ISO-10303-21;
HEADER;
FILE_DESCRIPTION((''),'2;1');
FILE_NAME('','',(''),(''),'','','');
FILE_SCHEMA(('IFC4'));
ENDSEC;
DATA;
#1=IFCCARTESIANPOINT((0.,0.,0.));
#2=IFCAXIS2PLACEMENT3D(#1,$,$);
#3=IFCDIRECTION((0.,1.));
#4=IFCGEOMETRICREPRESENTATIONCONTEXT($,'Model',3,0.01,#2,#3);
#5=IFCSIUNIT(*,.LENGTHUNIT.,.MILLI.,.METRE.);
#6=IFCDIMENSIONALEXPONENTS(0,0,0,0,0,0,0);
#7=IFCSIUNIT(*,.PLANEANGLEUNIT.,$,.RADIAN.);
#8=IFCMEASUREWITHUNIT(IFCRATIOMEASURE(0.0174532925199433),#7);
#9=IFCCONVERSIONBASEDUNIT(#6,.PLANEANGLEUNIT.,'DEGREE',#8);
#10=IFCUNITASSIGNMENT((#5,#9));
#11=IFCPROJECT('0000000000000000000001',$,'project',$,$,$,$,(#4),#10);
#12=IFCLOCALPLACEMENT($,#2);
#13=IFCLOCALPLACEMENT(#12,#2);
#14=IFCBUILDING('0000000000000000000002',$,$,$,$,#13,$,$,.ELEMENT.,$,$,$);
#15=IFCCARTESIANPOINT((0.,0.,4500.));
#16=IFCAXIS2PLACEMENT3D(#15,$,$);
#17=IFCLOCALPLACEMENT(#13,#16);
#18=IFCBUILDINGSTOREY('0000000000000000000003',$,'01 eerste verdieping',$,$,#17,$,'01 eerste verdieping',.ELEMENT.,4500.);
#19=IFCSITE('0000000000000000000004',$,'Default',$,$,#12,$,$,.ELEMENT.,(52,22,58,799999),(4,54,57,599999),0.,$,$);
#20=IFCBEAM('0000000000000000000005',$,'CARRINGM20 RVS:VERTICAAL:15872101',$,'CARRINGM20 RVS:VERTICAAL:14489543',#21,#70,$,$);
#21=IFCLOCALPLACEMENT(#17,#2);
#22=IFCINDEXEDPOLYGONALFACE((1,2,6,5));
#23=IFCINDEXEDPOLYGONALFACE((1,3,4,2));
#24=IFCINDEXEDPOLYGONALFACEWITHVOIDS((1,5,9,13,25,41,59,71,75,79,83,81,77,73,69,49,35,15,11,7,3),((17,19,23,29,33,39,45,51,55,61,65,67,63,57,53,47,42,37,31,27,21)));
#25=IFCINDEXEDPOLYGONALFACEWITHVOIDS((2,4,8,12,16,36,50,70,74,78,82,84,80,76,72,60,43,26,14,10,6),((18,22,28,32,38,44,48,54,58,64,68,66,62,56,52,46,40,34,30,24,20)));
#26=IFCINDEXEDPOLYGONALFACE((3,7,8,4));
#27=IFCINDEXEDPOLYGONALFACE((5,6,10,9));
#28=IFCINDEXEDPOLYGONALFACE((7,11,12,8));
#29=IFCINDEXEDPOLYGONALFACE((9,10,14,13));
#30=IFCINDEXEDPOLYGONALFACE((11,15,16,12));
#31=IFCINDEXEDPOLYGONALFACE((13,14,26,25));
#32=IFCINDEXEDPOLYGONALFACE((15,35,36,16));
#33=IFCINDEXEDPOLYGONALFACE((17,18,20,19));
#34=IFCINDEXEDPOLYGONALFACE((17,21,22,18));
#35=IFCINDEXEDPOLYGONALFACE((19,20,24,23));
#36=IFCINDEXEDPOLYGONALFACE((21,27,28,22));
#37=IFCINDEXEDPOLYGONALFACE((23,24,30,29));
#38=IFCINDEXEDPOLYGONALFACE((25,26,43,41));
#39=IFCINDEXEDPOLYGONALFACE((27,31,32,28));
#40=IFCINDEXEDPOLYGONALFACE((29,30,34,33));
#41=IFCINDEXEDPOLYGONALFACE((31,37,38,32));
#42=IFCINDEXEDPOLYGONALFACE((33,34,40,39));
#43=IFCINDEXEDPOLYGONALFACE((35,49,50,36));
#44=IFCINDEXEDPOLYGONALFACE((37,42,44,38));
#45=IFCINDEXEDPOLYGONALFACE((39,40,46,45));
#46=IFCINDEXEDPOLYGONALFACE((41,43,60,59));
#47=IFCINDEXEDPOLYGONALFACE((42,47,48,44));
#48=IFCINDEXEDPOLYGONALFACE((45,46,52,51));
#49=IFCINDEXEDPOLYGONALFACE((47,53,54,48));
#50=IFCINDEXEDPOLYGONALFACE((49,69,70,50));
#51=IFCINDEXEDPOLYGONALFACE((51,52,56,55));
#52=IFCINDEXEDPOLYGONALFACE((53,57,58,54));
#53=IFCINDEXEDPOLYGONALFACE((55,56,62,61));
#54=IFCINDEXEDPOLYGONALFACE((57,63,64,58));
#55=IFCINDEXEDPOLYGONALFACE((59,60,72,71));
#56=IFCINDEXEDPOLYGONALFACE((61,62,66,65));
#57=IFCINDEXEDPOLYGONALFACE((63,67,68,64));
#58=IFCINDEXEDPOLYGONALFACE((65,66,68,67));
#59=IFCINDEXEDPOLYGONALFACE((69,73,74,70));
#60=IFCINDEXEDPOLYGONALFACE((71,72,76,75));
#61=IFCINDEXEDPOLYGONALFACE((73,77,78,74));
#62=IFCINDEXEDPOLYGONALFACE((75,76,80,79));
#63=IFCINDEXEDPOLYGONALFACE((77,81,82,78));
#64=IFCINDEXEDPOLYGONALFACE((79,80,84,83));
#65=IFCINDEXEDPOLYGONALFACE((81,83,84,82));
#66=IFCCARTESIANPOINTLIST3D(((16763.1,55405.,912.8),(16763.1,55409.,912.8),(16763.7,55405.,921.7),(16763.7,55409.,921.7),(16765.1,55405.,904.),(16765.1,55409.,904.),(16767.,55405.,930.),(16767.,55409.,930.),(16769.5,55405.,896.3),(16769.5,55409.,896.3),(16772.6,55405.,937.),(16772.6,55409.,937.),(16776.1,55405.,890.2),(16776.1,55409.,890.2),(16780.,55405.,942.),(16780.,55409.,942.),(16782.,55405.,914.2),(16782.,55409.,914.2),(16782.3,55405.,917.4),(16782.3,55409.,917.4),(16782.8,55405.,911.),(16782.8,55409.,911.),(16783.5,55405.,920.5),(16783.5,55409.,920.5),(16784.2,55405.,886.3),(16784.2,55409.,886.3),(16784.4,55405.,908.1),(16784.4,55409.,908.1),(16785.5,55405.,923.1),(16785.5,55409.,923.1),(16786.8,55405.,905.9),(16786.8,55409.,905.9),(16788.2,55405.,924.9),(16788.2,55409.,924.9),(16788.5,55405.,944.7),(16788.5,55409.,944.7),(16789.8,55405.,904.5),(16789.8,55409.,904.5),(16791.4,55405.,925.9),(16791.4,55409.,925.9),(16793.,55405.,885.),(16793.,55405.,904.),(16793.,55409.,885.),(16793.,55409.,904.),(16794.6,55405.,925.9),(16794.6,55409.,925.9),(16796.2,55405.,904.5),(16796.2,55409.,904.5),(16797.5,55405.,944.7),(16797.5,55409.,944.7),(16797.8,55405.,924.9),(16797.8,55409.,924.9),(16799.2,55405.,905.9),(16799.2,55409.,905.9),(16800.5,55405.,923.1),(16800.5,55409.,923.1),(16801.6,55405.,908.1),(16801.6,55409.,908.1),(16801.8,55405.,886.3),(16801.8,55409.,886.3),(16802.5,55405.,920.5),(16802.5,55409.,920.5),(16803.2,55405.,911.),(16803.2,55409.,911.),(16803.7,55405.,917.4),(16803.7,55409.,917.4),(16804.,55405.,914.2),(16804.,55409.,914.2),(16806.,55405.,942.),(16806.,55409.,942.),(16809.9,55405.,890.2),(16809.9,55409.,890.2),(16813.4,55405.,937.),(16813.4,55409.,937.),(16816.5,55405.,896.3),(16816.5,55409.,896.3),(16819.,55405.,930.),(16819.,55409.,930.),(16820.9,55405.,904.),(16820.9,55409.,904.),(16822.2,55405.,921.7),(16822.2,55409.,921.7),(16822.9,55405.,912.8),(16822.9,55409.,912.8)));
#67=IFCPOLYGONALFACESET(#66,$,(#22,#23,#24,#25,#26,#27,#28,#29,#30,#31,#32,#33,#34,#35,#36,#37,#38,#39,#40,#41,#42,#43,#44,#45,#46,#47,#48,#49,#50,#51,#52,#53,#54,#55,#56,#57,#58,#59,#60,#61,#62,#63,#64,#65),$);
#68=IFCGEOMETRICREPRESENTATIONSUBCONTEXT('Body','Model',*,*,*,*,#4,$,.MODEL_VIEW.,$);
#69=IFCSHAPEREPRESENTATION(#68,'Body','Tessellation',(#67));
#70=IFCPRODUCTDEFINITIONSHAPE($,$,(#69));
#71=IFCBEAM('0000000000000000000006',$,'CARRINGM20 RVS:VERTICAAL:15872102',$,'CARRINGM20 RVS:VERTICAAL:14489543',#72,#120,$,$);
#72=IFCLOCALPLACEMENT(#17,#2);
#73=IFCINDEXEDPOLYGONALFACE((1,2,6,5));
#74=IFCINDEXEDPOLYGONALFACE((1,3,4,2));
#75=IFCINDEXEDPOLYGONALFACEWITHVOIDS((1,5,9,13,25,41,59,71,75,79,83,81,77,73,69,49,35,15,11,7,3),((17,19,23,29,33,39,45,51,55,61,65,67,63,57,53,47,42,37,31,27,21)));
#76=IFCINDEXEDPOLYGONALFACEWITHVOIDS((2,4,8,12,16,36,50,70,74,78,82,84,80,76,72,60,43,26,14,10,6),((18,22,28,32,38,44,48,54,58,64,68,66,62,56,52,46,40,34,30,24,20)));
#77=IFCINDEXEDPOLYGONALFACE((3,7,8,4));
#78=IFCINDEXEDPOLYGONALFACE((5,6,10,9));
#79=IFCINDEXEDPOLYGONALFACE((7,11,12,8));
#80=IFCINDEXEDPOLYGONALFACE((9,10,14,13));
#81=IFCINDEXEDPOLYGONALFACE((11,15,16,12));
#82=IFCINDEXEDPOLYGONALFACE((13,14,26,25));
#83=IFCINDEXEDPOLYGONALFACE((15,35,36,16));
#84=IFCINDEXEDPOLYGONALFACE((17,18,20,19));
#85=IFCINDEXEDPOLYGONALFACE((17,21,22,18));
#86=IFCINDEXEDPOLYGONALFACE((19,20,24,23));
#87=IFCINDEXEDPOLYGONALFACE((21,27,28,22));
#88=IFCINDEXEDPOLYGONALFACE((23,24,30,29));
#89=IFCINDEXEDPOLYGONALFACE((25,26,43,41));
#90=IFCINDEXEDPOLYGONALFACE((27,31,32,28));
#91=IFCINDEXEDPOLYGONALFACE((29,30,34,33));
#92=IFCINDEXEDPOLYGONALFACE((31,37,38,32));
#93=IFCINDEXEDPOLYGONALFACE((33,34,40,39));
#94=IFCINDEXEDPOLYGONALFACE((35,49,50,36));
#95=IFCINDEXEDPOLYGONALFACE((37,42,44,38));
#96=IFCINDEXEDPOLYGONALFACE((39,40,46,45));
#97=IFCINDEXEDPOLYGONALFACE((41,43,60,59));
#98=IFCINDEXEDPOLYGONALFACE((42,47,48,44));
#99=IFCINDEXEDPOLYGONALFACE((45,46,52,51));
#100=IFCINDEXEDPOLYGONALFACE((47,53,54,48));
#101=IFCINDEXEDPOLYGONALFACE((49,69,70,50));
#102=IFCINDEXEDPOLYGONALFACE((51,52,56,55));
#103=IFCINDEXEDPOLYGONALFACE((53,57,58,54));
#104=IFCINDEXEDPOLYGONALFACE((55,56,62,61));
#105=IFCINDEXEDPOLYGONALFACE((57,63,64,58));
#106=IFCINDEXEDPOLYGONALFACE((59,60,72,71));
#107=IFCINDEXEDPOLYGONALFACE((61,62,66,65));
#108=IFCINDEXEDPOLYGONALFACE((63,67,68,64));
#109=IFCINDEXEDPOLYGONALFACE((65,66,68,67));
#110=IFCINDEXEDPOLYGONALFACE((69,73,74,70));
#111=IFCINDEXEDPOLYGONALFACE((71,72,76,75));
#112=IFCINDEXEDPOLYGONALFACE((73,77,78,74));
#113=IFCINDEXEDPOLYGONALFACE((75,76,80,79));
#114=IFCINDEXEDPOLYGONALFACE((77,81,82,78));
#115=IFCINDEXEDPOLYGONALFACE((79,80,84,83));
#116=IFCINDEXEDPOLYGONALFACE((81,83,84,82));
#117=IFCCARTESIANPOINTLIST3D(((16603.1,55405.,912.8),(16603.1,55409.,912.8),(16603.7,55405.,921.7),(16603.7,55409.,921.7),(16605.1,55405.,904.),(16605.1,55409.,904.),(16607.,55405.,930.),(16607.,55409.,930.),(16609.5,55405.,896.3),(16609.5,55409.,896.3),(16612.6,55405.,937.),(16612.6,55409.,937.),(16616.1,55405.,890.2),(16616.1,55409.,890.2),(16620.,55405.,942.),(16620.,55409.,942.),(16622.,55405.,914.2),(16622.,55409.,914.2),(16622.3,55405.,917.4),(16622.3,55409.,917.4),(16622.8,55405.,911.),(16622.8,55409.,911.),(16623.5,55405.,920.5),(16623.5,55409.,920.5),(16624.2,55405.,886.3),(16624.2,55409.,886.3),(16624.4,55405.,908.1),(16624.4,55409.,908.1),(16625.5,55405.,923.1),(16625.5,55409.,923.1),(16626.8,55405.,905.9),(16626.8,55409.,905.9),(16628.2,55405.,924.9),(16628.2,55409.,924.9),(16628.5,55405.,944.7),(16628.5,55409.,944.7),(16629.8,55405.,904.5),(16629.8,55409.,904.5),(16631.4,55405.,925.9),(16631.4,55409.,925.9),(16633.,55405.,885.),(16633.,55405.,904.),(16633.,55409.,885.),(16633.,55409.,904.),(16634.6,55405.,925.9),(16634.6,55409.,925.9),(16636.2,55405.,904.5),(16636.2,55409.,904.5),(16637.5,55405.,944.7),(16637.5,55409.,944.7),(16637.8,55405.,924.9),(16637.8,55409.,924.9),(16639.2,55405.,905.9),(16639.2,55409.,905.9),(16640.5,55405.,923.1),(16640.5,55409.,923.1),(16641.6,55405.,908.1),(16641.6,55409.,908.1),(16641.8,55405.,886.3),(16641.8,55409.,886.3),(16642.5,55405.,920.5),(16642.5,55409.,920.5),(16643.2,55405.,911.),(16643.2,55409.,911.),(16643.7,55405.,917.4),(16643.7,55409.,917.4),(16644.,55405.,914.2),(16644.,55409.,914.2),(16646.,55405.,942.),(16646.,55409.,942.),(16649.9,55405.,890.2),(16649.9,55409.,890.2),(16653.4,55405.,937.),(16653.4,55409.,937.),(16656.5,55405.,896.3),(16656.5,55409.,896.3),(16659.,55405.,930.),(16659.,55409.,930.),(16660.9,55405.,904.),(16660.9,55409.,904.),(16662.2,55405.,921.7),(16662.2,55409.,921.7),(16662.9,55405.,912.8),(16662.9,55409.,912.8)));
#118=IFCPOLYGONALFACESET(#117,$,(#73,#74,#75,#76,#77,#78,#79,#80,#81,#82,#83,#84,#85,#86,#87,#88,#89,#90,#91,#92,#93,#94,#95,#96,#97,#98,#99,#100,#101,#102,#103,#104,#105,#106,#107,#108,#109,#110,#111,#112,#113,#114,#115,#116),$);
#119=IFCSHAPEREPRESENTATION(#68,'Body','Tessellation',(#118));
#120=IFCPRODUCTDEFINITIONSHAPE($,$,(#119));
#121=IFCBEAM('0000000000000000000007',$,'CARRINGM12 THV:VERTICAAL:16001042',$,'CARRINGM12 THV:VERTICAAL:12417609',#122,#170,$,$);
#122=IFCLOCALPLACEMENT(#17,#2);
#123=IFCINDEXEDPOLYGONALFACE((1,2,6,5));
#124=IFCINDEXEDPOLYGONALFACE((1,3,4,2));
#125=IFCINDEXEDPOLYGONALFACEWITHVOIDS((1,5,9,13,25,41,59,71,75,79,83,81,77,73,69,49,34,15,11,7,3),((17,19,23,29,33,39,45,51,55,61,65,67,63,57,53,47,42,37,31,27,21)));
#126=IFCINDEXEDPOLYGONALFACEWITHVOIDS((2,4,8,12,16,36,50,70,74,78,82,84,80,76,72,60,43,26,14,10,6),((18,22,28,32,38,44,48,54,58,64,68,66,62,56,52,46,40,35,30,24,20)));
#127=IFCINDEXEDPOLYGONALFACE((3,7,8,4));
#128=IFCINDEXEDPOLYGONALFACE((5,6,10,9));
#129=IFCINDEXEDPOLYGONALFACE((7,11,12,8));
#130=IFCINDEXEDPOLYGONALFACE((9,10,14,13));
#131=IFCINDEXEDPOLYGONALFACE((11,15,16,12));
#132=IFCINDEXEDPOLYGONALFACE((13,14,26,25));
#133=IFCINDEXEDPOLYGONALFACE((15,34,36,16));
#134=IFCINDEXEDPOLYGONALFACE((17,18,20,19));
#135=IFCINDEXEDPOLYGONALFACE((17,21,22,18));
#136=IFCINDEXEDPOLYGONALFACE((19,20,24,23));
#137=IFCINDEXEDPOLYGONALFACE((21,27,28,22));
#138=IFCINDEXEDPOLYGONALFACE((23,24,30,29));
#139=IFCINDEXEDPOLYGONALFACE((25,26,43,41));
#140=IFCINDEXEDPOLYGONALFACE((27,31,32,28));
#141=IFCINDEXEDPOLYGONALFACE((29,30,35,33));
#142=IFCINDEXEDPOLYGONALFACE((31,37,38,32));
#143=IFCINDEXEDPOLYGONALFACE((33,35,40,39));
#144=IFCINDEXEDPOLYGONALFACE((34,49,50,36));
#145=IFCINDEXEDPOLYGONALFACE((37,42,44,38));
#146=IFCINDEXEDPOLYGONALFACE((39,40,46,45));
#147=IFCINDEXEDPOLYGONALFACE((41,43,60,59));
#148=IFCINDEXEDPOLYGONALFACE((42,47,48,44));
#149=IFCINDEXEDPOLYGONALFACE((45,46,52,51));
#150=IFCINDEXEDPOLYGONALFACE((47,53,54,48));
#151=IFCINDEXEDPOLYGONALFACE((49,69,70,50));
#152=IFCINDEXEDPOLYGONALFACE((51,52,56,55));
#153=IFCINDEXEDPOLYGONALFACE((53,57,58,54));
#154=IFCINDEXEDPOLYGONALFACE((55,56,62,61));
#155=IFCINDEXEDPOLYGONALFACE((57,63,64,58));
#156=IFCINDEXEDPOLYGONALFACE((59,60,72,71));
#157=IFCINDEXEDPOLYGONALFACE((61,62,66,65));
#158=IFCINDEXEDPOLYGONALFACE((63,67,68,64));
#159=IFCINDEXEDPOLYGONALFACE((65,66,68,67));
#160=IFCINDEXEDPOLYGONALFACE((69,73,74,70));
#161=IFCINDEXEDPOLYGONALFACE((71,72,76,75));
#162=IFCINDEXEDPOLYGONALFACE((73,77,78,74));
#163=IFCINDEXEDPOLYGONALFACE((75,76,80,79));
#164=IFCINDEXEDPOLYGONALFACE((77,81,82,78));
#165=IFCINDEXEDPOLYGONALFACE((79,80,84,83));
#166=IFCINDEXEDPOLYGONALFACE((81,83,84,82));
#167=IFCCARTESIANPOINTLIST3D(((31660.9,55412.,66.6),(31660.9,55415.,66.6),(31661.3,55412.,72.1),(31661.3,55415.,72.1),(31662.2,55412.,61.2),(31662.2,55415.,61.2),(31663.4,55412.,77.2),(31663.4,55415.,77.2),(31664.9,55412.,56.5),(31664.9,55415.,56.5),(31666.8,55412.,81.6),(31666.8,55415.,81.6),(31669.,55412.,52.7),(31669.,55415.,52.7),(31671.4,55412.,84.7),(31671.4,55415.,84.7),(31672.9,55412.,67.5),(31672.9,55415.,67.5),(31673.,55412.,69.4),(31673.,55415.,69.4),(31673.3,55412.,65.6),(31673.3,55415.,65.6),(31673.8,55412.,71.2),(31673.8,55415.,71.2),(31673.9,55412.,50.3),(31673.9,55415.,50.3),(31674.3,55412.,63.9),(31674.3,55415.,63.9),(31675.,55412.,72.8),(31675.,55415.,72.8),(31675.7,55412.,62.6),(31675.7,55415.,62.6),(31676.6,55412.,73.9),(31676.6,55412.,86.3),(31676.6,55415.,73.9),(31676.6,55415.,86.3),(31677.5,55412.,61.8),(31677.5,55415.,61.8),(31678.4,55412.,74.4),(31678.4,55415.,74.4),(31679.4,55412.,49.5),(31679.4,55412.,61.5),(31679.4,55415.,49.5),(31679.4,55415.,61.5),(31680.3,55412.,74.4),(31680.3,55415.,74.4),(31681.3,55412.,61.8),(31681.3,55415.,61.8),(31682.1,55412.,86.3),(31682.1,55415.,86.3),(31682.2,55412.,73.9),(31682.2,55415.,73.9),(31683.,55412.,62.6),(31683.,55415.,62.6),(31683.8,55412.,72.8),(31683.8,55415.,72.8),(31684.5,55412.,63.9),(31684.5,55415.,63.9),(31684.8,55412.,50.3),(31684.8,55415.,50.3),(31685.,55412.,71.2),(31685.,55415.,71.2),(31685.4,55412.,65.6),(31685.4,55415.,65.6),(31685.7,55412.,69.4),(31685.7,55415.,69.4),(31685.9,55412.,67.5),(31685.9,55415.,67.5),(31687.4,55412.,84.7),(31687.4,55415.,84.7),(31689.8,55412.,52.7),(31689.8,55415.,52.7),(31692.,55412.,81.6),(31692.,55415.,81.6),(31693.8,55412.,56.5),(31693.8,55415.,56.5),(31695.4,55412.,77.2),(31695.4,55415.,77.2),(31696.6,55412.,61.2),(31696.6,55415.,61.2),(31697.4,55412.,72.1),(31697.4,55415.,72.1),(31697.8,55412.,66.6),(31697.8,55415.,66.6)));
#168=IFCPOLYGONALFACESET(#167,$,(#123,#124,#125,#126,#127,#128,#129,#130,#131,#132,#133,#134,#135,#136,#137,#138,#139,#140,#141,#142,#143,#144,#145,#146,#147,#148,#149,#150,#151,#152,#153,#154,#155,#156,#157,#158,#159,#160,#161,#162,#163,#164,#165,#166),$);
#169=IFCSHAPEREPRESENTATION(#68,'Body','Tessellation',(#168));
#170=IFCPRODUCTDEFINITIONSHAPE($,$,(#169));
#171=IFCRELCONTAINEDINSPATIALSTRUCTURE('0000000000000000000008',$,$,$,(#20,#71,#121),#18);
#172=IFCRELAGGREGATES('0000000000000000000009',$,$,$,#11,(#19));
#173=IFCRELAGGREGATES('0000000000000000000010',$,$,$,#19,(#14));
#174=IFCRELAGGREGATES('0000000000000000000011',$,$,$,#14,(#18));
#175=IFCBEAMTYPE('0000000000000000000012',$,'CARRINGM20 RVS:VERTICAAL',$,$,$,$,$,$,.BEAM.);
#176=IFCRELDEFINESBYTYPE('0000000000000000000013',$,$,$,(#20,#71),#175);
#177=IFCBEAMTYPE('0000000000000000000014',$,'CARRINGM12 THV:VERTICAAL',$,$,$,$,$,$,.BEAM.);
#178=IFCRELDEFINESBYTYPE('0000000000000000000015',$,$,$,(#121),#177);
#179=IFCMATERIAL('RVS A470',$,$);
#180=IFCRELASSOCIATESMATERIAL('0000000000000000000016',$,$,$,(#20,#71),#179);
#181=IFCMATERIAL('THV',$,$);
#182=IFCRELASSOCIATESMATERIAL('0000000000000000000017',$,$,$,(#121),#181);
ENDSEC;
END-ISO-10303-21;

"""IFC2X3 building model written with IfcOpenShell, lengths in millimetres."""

from ifc_helpers import new_model, entity, si_unit, converted_unit, direction, frame, origin, origin_2d_with_axis, place, context, subcontext, project, spatial, hollow_circle, extrude, material, type_object, element, save


model = new_model("IFC2X3")

# Units and contexts
model_context = context("Model", 3, precision=0.01, world=origin(), true_north=direction((0.0, 1.0)))
body_context = subcontext(model_context, "Body", "Model", "MODEL_VIEW")
ifc_project = project(units=[si_unit("LENGTHUNIT", "METRE", prefix="MILLI"), converted_unit("PLANEANGLEUNIT", "DEGREE", entity("IfcRatioMeasure", 0.0174532925199433), si_unit("PLANEANGLEUNIT", "RADIAN"), dimensions=[0, 0, 0, 0, 0, 0, 0])], contexts=[model_context])

# Site, building, storey
site_placement = place(None, origin())
site = spatial("IfcSite", under=ifc_project, at=site_placement, Name="Default", CompositionType="ELEMENT", RefLatitude=(52, 22, 58, 799999), RefLongitude=(4, 54, 57, 599999), RefElevation=0.0)
building_placement = place(site_placement, origin())
building = spatial("IfcBuilding", under=site, at=building_placement, CompositionType="ELEMENT")
storey_placement = place(building_placement, frame((0.0, 0.0, 4500.0)))
storey = spatial("IfcBuildingStorey", under=building, at=storey_placement, Name="01 eerste verdieping", LongName="01 eerste verdieping", CompositionType="ELEMENT", Elevation=4500.0)

# Beams
ifc_material_1 = material(Name="RVS A470")
beam_type_1 = type_object("IfcBeamType", Name="CARRINGM20 RVS:VERTICAAL", PredefinedType="BEAM")
beam_1_placement = place(storey_placement, origin())
element("IfcBeam", 1, at=beam_1_placement, inside=storey, type_object=beam_type_1, material=ifc_material_1, Name="CARRINGM20 RVS:VERTICAAL:15872101", ObjectType="CARRINGM20 RVS:VERTICAAL:14489543", context=body_context, shape_type="SweptSolid", body=[
    extrude(hollow_circle(Radius=30.0, WallThickness=19.0, at=origin_2d_with_axis()), frame((16793.0, 55405.0, 915.0), z_axis=(0.0, 1.0, 0.0), x_axis=(0.0, 0.0, -1.0)), (0.0, 0.0, 1.0), 4.0),
])
beam_2_placement = place(storey_placement, origin())
element("IfcBeam", 2, at=beam_2_placement, inside=storey, type_object=beam_type_1, material=ifc_material_1, Name="CARRINGM20 RVS:VERTICAAL:15872102", ObjectType="CARRINGM20 RVS:VERTICAAL:14489543", context=body_context, shape_type="SweptSolid", body=[
    extrude(hollow_circle(Radius=30.0, WallThickness=19.0, at=origin_2d_with_axis()), frame((16633.0, 55405.0, 915.0), z_axis=(0.0, 1.0, 0.0), x_axis=(0.0, 0.0, -1.0)), (0.0, 0.0, 1.0), 4.0),
])
ifc_material_2 = material(Name="THV")
beam_type_2 = type_object("IfcBeamType", Name="CARRINGM12 THV:VERTICAAL", PredefinedType="BEAM")
beam_3_placement = place(storey_placement, origin())
element("IfcBeam", 3, at=beam_3_placement, inside=storey, type_object=beam_type_2, material=ifc_material_2, Name="CARRINGM12 THV:VERTICAAL:16001042", ObjectType="CARRINGM12 THV:VERTICAAL:12417609", context=body_context, shape_type="SweptSolid", body=[
    extrude(hollow_circle(Radius=18.5, WallThickness=12.0, at=origin_2d_with_axis()), frame((31679.4, 55412.0, 68.0), z_axis=(0.0, 1.0, 0.0), x_axis=(0.0, 0.0, -1.0)), (0.0, 0.0, 1.0), 3.0),
])

save(model, "model.ifc")
